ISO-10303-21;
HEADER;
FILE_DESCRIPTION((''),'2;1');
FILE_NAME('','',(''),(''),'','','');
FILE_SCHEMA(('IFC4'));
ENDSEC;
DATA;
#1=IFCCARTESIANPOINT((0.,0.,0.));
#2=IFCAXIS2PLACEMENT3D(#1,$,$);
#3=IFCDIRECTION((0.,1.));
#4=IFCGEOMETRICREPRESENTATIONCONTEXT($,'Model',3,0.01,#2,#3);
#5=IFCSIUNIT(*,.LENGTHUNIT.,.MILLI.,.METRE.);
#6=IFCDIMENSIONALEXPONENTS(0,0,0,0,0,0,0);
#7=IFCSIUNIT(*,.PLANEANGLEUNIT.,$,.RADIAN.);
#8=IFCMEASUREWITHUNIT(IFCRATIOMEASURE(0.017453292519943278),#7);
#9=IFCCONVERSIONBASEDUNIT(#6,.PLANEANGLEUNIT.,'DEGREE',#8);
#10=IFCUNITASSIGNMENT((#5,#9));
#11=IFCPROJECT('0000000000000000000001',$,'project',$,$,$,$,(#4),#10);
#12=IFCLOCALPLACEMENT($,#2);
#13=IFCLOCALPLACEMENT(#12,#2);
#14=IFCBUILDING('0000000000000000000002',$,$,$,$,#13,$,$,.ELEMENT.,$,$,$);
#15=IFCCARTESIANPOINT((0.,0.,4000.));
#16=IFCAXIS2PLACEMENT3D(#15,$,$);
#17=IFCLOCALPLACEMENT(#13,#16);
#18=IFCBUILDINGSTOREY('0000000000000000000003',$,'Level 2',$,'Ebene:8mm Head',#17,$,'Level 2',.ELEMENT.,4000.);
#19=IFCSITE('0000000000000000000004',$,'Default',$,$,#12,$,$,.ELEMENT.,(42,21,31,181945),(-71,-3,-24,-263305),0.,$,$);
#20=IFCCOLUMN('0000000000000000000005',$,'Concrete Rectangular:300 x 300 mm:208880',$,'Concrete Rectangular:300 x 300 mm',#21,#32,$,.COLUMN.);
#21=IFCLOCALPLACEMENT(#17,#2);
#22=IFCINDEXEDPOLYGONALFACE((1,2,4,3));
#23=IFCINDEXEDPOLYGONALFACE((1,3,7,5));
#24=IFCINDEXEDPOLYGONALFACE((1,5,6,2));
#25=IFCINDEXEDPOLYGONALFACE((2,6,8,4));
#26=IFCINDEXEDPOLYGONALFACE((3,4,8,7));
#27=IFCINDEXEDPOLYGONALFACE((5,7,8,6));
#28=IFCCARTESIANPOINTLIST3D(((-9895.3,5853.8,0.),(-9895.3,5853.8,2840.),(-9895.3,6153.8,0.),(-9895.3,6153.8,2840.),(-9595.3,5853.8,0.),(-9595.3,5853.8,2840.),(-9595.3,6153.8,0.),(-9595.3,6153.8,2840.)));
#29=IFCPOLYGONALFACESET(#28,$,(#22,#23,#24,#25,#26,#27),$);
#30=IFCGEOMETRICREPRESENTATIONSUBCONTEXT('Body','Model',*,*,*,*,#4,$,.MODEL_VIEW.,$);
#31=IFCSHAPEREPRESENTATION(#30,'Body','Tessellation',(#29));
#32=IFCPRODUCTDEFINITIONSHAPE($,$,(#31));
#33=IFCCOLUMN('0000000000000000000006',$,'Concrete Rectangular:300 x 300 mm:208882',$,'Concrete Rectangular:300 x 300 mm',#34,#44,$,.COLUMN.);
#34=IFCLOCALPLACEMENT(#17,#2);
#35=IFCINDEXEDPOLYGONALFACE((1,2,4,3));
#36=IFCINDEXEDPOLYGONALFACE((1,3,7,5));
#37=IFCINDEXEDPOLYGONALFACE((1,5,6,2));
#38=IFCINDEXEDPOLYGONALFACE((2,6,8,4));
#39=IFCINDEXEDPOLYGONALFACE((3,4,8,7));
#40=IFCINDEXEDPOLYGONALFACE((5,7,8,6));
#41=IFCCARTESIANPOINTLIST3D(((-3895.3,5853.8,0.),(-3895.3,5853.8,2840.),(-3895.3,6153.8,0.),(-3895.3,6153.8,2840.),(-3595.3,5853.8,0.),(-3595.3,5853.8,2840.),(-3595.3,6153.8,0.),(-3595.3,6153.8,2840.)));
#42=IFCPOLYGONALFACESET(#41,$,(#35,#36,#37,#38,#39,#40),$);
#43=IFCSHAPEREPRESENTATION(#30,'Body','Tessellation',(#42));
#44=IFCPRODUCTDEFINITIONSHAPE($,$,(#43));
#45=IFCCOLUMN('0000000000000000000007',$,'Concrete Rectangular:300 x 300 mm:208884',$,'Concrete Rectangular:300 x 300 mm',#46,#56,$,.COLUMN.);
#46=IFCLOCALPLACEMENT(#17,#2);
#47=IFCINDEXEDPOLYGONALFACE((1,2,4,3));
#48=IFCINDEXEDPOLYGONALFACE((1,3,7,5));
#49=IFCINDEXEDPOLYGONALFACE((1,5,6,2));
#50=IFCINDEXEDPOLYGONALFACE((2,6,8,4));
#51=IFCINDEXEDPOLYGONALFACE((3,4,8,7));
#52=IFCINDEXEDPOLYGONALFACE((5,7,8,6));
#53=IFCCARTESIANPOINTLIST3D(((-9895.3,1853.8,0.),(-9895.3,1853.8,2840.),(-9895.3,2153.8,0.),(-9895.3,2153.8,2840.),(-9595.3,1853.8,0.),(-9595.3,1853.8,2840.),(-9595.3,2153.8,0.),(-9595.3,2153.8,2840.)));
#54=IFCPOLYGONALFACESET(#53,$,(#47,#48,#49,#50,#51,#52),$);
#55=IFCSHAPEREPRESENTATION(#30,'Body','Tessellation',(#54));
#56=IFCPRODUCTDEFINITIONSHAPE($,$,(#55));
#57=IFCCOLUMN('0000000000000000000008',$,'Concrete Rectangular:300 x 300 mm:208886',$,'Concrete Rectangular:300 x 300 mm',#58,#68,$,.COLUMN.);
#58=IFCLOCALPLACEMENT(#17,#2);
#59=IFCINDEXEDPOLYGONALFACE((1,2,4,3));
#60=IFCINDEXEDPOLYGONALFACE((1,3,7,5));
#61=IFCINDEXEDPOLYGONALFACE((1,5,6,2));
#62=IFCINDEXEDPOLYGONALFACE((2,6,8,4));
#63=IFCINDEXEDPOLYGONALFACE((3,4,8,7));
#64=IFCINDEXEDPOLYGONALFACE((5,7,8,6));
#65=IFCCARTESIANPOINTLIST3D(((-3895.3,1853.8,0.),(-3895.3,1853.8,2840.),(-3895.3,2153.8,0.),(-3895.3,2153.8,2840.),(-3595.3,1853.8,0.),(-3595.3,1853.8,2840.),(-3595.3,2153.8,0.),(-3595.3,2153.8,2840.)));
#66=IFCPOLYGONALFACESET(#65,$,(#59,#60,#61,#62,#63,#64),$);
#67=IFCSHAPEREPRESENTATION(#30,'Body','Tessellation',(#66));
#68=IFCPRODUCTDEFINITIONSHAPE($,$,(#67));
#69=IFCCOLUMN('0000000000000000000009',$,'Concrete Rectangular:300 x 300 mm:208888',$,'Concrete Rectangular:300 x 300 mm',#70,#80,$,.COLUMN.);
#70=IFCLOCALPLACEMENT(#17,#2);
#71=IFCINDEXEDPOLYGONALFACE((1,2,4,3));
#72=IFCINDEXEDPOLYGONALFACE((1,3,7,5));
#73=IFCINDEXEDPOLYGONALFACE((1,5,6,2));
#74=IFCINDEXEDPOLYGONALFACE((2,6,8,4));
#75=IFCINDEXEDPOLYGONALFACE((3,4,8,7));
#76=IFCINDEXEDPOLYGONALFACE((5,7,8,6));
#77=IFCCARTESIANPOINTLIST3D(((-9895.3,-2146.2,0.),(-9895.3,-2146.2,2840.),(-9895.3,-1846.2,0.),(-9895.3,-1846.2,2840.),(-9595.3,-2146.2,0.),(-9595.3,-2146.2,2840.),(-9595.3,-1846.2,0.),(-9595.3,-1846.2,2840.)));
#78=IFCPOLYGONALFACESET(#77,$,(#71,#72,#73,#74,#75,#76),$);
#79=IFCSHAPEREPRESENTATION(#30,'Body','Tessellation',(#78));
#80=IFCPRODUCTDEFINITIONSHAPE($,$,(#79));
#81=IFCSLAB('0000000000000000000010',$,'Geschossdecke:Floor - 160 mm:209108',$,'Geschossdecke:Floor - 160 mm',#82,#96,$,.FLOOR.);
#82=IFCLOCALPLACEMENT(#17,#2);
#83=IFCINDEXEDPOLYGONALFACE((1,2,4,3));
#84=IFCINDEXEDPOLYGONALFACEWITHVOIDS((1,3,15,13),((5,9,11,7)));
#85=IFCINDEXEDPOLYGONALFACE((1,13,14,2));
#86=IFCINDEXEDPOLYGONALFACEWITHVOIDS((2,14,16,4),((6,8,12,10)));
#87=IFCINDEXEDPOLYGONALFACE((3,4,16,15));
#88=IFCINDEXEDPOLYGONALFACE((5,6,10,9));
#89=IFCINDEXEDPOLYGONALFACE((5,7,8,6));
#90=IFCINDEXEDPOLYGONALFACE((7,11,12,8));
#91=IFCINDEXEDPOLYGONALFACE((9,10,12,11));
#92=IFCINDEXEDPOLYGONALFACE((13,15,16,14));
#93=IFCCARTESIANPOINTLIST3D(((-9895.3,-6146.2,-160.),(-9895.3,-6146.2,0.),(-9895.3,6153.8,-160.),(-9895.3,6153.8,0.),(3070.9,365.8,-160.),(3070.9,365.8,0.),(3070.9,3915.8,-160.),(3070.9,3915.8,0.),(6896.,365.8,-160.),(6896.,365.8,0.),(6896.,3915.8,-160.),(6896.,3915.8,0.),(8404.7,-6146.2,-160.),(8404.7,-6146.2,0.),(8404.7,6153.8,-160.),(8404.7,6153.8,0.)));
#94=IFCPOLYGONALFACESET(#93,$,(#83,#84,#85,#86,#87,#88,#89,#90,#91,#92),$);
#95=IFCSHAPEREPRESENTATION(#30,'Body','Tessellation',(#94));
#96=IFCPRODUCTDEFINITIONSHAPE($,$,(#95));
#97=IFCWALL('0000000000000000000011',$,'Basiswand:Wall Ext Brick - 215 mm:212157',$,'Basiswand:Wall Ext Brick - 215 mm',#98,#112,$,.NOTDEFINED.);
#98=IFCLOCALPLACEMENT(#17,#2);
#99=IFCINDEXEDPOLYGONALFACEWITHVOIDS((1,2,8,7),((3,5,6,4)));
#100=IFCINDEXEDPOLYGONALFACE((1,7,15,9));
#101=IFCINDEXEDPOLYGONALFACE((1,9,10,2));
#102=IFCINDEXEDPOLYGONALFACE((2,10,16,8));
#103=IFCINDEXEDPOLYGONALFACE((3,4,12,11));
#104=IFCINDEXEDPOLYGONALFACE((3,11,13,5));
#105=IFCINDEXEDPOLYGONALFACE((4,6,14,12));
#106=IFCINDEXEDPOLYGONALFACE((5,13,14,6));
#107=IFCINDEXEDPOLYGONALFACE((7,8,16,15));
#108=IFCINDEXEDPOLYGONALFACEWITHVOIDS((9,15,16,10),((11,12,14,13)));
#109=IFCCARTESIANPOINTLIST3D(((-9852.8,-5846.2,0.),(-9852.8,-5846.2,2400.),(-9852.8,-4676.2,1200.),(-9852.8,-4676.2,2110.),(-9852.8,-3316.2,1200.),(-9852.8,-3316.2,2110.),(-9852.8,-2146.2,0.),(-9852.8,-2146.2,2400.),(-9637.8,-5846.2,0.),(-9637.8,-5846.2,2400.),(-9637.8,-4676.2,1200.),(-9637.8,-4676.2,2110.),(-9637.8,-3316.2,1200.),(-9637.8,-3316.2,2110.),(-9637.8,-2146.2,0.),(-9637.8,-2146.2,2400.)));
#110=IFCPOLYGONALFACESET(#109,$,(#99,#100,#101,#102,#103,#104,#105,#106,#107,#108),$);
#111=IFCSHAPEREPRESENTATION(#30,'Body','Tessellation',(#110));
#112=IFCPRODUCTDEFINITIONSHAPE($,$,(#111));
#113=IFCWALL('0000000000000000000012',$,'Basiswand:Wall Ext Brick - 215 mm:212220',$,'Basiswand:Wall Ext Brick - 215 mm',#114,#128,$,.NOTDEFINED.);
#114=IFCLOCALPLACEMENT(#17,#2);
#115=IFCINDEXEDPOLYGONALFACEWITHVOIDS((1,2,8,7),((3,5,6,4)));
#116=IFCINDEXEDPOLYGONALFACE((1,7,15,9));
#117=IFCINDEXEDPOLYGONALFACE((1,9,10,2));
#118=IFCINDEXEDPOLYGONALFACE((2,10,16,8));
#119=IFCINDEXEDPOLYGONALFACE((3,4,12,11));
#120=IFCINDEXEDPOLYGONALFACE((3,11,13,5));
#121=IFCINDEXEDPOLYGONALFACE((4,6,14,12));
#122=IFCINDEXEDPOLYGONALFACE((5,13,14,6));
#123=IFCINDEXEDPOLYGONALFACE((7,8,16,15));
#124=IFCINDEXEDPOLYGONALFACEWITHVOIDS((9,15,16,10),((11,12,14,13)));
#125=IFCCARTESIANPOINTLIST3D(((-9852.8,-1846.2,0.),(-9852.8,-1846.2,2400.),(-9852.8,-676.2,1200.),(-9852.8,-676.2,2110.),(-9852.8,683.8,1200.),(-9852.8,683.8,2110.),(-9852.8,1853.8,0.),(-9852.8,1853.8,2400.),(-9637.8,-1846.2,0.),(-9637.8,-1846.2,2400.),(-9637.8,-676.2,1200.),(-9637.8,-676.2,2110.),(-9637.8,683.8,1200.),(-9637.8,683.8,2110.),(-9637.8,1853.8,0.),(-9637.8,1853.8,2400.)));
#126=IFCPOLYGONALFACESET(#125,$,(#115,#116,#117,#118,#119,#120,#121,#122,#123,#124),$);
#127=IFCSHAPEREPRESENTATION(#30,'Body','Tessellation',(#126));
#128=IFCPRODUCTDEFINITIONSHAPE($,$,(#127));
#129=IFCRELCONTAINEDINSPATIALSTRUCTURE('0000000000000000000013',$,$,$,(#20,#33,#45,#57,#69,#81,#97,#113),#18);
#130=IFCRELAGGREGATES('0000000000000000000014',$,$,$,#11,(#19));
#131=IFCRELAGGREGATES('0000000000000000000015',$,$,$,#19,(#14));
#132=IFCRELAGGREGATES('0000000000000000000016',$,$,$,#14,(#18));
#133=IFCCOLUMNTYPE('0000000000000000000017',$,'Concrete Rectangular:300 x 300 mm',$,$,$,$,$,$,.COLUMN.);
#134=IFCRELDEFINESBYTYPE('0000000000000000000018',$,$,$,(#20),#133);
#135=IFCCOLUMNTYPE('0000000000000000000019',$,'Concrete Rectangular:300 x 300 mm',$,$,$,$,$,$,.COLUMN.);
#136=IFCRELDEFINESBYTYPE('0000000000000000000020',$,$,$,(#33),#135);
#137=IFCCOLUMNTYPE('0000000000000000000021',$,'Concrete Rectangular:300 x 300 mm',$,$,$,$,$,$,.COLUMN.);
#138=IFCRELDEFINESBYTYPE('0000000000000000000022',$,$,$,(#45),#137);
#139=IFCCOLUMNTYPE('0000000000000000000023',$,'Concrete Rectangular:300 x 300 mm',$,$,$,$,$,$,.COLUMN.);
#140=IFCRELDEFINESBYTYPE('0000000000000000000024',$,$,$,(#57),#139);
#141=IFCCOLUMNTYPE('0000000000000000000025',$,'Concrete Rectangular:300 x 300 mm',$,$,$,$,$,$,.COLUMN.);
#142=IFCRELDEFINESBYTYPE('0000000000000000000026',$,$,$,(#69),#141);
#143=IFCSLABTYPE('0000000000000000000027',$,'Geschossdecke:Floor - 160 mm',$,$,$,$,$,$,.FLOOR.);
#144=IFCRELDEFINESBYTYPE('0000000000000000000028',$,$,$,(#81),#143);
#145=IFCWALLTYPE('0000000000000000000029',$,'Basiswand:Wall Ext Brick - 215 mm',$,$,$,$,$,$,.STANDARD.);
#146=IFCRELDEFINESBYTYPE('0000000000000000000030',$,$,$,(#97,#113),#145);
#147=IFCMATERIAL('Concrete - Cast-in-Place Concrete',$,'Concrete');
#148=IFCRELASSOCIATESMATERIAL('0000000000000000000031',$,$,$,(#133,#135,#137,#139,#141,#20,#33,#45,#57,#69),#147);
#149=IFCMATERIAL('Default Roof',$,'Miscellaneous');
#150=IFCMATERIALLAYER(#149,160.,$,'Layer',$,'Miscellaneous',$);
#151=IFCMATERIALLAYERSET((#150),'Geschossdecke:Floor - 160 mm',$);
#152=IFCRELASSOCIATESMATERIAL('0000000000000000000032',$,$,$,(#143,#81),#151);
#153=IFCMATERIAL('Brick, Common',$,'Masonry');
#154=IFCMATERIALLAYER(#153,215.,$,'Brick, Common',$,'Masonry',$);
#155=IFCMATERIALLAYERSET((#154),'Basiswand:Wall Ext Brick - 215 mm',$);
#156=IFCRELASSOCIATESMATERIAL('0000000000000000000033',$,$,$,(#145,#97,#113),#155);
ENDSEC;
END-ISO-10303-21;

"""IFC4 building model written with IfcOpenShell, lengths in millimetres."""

from ifc_helpers import new_model, entity, si_unit, converted_unit, direction, frame, frame_2d, origin, origin_2d_with_axis, place, context, subcontext, project, spatial, polyline, segment, composite_curve, rectangle, outline, extrude, source, transform, mapped, material, layer, layer_set, layer_usage, material_profile, profile_set, profile_usage, type_object, type_shapes, element, save


model = new_model("IFC4")

# Units and contexts
model_context = context("Model", 3, precision=0.01, world=origin(), true_north=direction((0.0, 1.0)))
body_context = subcontext(model_context, "Body", "Model", "MODEL_VIEW")
ifc_project = project(units=[si_unit("LENGTHUNIT", "METRE", prefix="MILLI"), converted_unit("PLANEANGLEUNIT", "DEGREE", entity("IfcRatioMeasure", 0.017453292519943278), si_unit("PLANEANGLEUNIT", "RADIAN"), dimensions=[0, 0, 0, 0, 0, 0, 0])], contexts=[model_context])

# Site, building, storey
site_placement = place(None, origin())
site = spatial("IfcSite", under=ifc_project, at=site_placement, Name="Default", CompositionType="ELEMENT", RefLatitude=(42, 21, 31, 181945), RefLongitude=(-71, -3, -24, -263305), RefElevation=0.0)
building_placement = place(site_placement, origin())
building = spatial("IfcBuilding", under=site, at=building_placement, CompositionType="ELEMENT")
storey_placement = place(building_placement, frame((0.0, 0.0, 4000.0)))
storey = spatial("IfcBuildingStorey", under=building, at=storey_placement, Name="Level 2", ObjectType="Ebene:8mm Head", LongName="Level 2", CompositionType="ELEMENT", Elevation=4000.0)

# Columns
ifc_material_1 = material(Name="Concrete - Cast-in-Place Concrete", Category="Concrete")
ifc_material_profile_1 = material_profile(ifc_material_1, outline(composite_curve([segment(polyline([(150.0, 150.0, 0.0), (150.0, -150.0, 0.0)]), True, "CONTINUOUS"), segment(polyline([(150.0, -150.0, 0.0), (-150.0, -150.0, 0.0)]), True, "CONTINUOUS"), segment(polyline([(-150.0, -150.0, 0.0), (-150.0, 150.0, 0.0)]), True, "CONTINUOUS"), segment(polyline([(-150.0, 150.0, 0.0), (150.0, 150.0, 0.0)]), True, "CONTINUOUS")], self_intersect=False), kind="CURVE"), Name="300 x 300 mm")
ifc_material_profile_2 = material_profile(ifc_material_1, outline(composite_curve([segment(polyline([(150.0, 150.0, 4000.0), (-150.0, 150.0, 4000.0)]), True, "CONTINUOUS"), segment(polyline([(-150.0, 150.0, 4000.0), (-150.0, -150.0, 4000.0)]), True, "CONTINUOUS"), segment(polyline([(-150.0, -150.0, 4000.0), (150.0, -150.0, 4000.0)]), True, "CONTINUOUS"), segment(polyline([(150.0, -150.0, 4000.0), (150.0, 150.0, 4000.0)]), True, "CONTINUOUS")], self_intersect=False), kind="CURVE"), Name="300 x 300 mm")
ifc_profile_set = profile_set([ifc_material_profile_1, ifc_material_profile_2], Name="300 x 300 mm")
ifc_profile_usage_1 = profile_usage(ifc_profile_set)
column_type_1 = type_object("IfcColumnType", Name="Concrete Rectangular:300 x 300 mm", PredefinedType="COLUMN", material=ifc_profile_set)
shared_shape_1 = source(origin(), body_context, "Body", "SweptSolid", [
    extrude(rectangle(XDim=300.0, YDim=300.0, at=frame_2d((0.0, 0.0), x_axis=(1.0, 0.0))), frame((-9745.3, 6003.8, 4000.0), z_axis=(0.0, 0.0, 1.0), x_axis=(0.0, -1.0, 0.0)), (0.0, 0.0, 1.0), 2840.0),
])
type_shapes(column_type_1, [shared_shape_1])
column_1_placement = place(storey_placement, frame((0.0, 0.0, -4000.0)))
element("IfcColumn", 1, at=column_1_placement, inside=storey, type_object=column_type_1, material=ifc_profile_usage_1, Name="Concrete Rectangular:300 x 300 mm:208880", ObjectType="Concrete Rectangular:300 x 300 mm", PredefinedType="COLUMN", context=body_context, shape_type="MappedRepresentation", body=[
    mapped(shared_shape_1, transform((0.0, 0.0, 0.0), scale=1.0)),
])
ifc_profile_usage_2 = profile_usage(ifc_profile_set)
column_type_2 = type_object("IfcColumnType", Name="Concrete Rectangular:300 x 300 mm", PredefinedType="COLUMN", material=ifc_profile_set)
shared_shape_2 = source(origin(), body_context, "Body", "SweptSolid", [
    extrude(rectangle(XDim=300.0, YDim=300.0, at=frame_2d((0.0, 0.0), x_axis=(1.0, 0.0))), frame((-3745.3, 6003.8, 4000.0), z_axis=(0.0, 0.0, 1.0), x_axis=(0.0, -1.0, 0.0)), (0.0, 0.0, 1.0), 2840.0),
])
type_shapes(column_type_2, [shared_shape_2])
column_2_placement = place(storey_placement, frame((0.0, 0.0, -4000.0)))
element("IfcColumn", 2, at=column_2_placement, inside=storey, type_object=column_type_2, material=ifc_profile_usage_2, Name="Concrete Rectangular:300 x 300 mm:208882", ObjectType="Concrete Rectangular:300 x 300 mm", PredefinedType="COLUMN", context=body_context, shape_type="MappedRepresentation", body=[
    mapped(shared_shape_2, transform((0.0, 0.0, 0.0), scale=1.0)),
])
ifc_profile_usage_3 = profile_usage(ifc_profile_set)
column_type_3 = type_object("IfcColumnType", Name="Concrete Rectangular:300 x 300 mm", PredefinedType="COLUMN", material=ifc_profile_set)
shared_shape_3 = source(origin(), body_context, "Body", "SweptSolid", [
    extrude(rectangle(XDim=300.0, YDim=300.0, at=frame_2d((0.0, 0.0), x_axis=(1.0, 0.0))), frame((-9745.3, 2003.8, 4000.0), z_axis=(0.0, 0.0, 1.0), x_axis=(0.0, -1.0, 0.0)), (0.0, 0.0, 1.0), 2840.0),
])
type_shapes(column_type_3, [shared_shape_3])
column_3_placement = place(storey_placement, frame((0.0, 0.0, -4000.0)))
element("IfcColumn", 3, at=column_3_placement, inside=storey, type_object=column_type_3, material=ifc_profile_usage_3, Name="Concrete Rectangular:300 x 300 mm:208884", ObjectType="Concrete Rectangular:300 x 300 mm", PredefinedType="COLUMN", context=body_context, shape_type="MappedRepresentation", body=[
    mapped(shared_shape_3, transform((0.0, 0.0, 0.0), scale=1.0)),
])
ifc_profile_usage_4 = profile_usage(ifc_profile_set)
column_type_4 = type_object("IfcColumnType", Name="Concrete Rectangular:300 x 300 mm", PredefinedType="COLUMN", material=ifc_profile_set)
shared_shape_4 = source(origin(), body_context, "Body", "SweptSolid", [
    extrude(rectangle(XDim=300.0, YDim=300.0, at=origin_2d_with_axis()), frame((-3745.3, 2003.8, 4000.0), z_axis=(0.0, 0.0, 1.0), x_axis=(0.0, -1.0, 0.0)), (0.0, 0.0, 1.0), 2840.0),
])
type_shapes(column_type_4, [shared_shape_4])
column_4_placement = place(storey_placement, frame((0.0, 0.0, -4000.0)))
element("IfcColumn", 4, at=column_4_placement, inside=storey, type_object=column_type_4, material=ifc_profile_usage_4, Name="Concrete Rectangular:300 x 300 mm:208886", ObjectType="Concrete Rectangular:300 x 300 mm", PredefinedType="COLUMN", context=body_context, shape_type="MappedRepresentation", body=[
    mapped(shared_shape_4, transform((0.0, 0.0, 0.0), scale=1.0)),
])
ifc_profile_usage_5 = profile_usage(ifc_profile_set)
column_type_5 = type_object("IfcColumnType", Name="Concrete Rectangular:300 x 300 mm", PredefinedType="COLUMN", material=ifc_profile_set)
shared_shape_5 = source(origin(), body_context, "Body", "SweptSolid", [
    extrude(rectangle(XDim=300.0, YDim=300.0, at=frame_2d((0.0, 0.0), x_axis=(1.0, 0.0))), frame((-9745.3, -1996.2, 4000.0), z_axis=(0.0, 0.0, 1.0), x_axis=(0.0, -1.0, 0.0)), (0.0, 0.0, 1.0), 2840.0),
])
type_shapes(column_type_5, [shared_shape_5])
column_5_placement = place(storey_placement, frame((0.0, 0.0, -4000.0)))
element("IfcColumn", 5, at=column_5_placement, inside=storey, type_object=column_type_5, material=ifc_profile_usage_5, Name="Concrete Rectangular:300 x 300 mm:208888", ObjectType="Concrete Rectangular:300 x 300 mm", PredefinedType="COLUMN", context=body_context, shape_type="MappedRepresentation", body=[
    mapped(shared_shape_5, transform((0.0, 0.0, 0.0), scale=1.0)),
])

# Slab, opening
ifc_material_2 = material(Name="Default Roof", Category="Miscellaneous")
ifc_layer_1 = layer(ifc_material_2, 160.0, Name="Layer", Category="Miscellaneous")
ifc_layer_set_1 = layer_set([ifc_layer_1], Name="Geschossdecke:Floor - 160 mm")
ifc_layer_usage_1 = layer_usage(ifc_layer_set_1, "AXIS3", "POSITIVE", 0.0)
slab_type = type_object("IfcSlabType", Name="Geschossdecke:Floor - 160 mm", PredefinedType="FLOOR", material=ifc_layer_set_1)
slab_placement = place(storey_placement, frame((-9895.3, -6146.2, -160.0)))
slab = element("IfcSlab", 6, at=slab_placement, inside=storey, type_object=slab_type, material=ifc_layer_usage_1, Name="Geschossdecke:Floor - 160 mm:209108", ObjectType="Geschossdecke:Floor - 160 mm", PredefinedType="FLOOR", context=body_context, shape_type="SweptSolid", body=[
    extrude(rectangle(XDim=12300.0, YDim=18300.0, at=frame_2d((0.0, 0.0), x_axis=(0.0, -1.0))), frame((9150.0, 6150.0, 160.0), z_axis=(0.0, 0.0, -1.0), x_axis=(-1.0, 0.0, 0.0)), (0.0, 0.0, 1.0), 160.0),
])
opening_1_placement = place(storey_placement, frame((-9895.3, -6146.2, -160.0)))
element("IfcOpeningElement", 7, at=opening_1_placement, cuts=slab, ObjectType="Opening", context=body_context, shape_type="SweptSolid", body=[
    extrude(rectangle(XDim=3550.0, YDim=3825.0, at=frame_2d((-5728.7, 2137.0), x_axis=(0.0, 1.0))), frame((9150.0, 6150.0, 160.0), z_axis=(0.0, 0.0, -1.0), x_axis=(-1.0, 0.0, 0.0)), (0.0, 0.0, 1.0), 160.0),
])

# Walls, openings
ifc_material_3 = material(Name="Brick, Common", Category="Masonry")
ifc_layer_2 = layer(ifc_material_3, 215.0, Name="Brick, Common", Category="Masonry")
ifc_layer_set_2 = layer_set([ifc_layer_2], Name="Basiswand:Wall Ext Brick - 215 mm")
ifc_layer_usage_2 = layer_usage(ifc_layer_set_2, "AXIS2", "NEGATIVE", 107.5)
wall_type_1 = type_object("IfcWallType", Name="Basiswand:Wall Ext Brick - 215 mm", PredefinedType="STANDARD", material=ifc_layer_set_2)
wall_1_placement = place(storey_placement, frame((-9745.3, -5846.2, 0.0), z_axis=(0.0, 0.0, 1.0), x_axis=(0.0, 1.0, 0.0)))
wall_1 = element("IfcWall", 8, at=wall_1_placement, inside=storey, type_object=wall_type_1, material=ifc_layer_usage_2, Name="Basiswand:Wall Ext Brick - 215 mm:212157", ObjectType="Basiswand:Wall Ext Brick - 215 mm", PredefinedType="NOTDEFINED", context=body_context, shape_type="SweptSolid", body=[
    extrude(rectangle(XDim=3700.0, YDim=215.0, at=frame_2d((1850.0, 0.0), x_axis=(-1.0, 0.0))), origin(), (0.0, 0.0, 1.0), 2400.0),
])
opening_2_placement = place(wall_1_placement, frame((2530.0, 107.5, 1200.0)))
element("IfcOpeningElement", 9, at=opening_2_placement, cuts=wall_1, PredefinedType="OPENING", context=body_context, shape_type="SweptSolid", body=[
    extrude(rectangle(XDim=910.0, YDim=1360.0, at=frame_2d((455.0, 680.0), x_axis=(-1.0, 0.0))), frame((0.0, 0.0, 0.0), z_axis=(0.0, -1.0, 0.0), x_axis=(0.0, 0.0, 1.0)), (0.0, 0.0, 1.0), 215.0),
])
ifc_layer_usage_3 = layer_usage(ifc_layer_set_2, "AXIS2", "NEGATIVE", 107.5)
wall_2_placement = place(storey_placement, frame((-9745.3, -1846.2, 0.0), z_axis=(0.0, 0.0, 1.0), x_axis=(0.0, 1.0, 0.0)))
wall_2 = element("IfcWall", 10, at=wall_2_placement, inside=storey, type_object=wall_type_1, material=ifc_layer_usage_3, Name="Basiswand:Wall Ext Brick - 215 mm:212220", ObjectType="Basiswand:Wall Ext Brick - 215 mm", PredefinedType="NOTDEFINED", context=body_context, shape_type="SweptSolid", body=[
    extrude(rectangle(XDim=3700.0, YDim=215.0, at=frame_2d((1850.0, 0.0), x_axis=(-1.0, 0.0))), origin(), (0.0, 0.0, 1.0), 2400.0),
])
opening_3_placement = place(wall_2_placement, frame((2530.0, 107.5, 1200.0)))
element("IfcOpeningElement", 11, at=opening_3_placement, cuts=wall_2, PredefinedType="OPENING", context=body_context, shape_type="SweptSolid", body=[
    extrude(rectangle(XDim=910.0, YDim=1360.0, at=frame_2d((455.0, 680.0), x_axis=(-1.0, 0.0))), frame((0.0, 0.0, 0.0), z_axis=(0.0, -1.0, 0.0), x_axis=(0.0, 0.0, 1.0)), (0.0, 0.0, 1.0), 215.0),
])

save(model, "model.ifc")
